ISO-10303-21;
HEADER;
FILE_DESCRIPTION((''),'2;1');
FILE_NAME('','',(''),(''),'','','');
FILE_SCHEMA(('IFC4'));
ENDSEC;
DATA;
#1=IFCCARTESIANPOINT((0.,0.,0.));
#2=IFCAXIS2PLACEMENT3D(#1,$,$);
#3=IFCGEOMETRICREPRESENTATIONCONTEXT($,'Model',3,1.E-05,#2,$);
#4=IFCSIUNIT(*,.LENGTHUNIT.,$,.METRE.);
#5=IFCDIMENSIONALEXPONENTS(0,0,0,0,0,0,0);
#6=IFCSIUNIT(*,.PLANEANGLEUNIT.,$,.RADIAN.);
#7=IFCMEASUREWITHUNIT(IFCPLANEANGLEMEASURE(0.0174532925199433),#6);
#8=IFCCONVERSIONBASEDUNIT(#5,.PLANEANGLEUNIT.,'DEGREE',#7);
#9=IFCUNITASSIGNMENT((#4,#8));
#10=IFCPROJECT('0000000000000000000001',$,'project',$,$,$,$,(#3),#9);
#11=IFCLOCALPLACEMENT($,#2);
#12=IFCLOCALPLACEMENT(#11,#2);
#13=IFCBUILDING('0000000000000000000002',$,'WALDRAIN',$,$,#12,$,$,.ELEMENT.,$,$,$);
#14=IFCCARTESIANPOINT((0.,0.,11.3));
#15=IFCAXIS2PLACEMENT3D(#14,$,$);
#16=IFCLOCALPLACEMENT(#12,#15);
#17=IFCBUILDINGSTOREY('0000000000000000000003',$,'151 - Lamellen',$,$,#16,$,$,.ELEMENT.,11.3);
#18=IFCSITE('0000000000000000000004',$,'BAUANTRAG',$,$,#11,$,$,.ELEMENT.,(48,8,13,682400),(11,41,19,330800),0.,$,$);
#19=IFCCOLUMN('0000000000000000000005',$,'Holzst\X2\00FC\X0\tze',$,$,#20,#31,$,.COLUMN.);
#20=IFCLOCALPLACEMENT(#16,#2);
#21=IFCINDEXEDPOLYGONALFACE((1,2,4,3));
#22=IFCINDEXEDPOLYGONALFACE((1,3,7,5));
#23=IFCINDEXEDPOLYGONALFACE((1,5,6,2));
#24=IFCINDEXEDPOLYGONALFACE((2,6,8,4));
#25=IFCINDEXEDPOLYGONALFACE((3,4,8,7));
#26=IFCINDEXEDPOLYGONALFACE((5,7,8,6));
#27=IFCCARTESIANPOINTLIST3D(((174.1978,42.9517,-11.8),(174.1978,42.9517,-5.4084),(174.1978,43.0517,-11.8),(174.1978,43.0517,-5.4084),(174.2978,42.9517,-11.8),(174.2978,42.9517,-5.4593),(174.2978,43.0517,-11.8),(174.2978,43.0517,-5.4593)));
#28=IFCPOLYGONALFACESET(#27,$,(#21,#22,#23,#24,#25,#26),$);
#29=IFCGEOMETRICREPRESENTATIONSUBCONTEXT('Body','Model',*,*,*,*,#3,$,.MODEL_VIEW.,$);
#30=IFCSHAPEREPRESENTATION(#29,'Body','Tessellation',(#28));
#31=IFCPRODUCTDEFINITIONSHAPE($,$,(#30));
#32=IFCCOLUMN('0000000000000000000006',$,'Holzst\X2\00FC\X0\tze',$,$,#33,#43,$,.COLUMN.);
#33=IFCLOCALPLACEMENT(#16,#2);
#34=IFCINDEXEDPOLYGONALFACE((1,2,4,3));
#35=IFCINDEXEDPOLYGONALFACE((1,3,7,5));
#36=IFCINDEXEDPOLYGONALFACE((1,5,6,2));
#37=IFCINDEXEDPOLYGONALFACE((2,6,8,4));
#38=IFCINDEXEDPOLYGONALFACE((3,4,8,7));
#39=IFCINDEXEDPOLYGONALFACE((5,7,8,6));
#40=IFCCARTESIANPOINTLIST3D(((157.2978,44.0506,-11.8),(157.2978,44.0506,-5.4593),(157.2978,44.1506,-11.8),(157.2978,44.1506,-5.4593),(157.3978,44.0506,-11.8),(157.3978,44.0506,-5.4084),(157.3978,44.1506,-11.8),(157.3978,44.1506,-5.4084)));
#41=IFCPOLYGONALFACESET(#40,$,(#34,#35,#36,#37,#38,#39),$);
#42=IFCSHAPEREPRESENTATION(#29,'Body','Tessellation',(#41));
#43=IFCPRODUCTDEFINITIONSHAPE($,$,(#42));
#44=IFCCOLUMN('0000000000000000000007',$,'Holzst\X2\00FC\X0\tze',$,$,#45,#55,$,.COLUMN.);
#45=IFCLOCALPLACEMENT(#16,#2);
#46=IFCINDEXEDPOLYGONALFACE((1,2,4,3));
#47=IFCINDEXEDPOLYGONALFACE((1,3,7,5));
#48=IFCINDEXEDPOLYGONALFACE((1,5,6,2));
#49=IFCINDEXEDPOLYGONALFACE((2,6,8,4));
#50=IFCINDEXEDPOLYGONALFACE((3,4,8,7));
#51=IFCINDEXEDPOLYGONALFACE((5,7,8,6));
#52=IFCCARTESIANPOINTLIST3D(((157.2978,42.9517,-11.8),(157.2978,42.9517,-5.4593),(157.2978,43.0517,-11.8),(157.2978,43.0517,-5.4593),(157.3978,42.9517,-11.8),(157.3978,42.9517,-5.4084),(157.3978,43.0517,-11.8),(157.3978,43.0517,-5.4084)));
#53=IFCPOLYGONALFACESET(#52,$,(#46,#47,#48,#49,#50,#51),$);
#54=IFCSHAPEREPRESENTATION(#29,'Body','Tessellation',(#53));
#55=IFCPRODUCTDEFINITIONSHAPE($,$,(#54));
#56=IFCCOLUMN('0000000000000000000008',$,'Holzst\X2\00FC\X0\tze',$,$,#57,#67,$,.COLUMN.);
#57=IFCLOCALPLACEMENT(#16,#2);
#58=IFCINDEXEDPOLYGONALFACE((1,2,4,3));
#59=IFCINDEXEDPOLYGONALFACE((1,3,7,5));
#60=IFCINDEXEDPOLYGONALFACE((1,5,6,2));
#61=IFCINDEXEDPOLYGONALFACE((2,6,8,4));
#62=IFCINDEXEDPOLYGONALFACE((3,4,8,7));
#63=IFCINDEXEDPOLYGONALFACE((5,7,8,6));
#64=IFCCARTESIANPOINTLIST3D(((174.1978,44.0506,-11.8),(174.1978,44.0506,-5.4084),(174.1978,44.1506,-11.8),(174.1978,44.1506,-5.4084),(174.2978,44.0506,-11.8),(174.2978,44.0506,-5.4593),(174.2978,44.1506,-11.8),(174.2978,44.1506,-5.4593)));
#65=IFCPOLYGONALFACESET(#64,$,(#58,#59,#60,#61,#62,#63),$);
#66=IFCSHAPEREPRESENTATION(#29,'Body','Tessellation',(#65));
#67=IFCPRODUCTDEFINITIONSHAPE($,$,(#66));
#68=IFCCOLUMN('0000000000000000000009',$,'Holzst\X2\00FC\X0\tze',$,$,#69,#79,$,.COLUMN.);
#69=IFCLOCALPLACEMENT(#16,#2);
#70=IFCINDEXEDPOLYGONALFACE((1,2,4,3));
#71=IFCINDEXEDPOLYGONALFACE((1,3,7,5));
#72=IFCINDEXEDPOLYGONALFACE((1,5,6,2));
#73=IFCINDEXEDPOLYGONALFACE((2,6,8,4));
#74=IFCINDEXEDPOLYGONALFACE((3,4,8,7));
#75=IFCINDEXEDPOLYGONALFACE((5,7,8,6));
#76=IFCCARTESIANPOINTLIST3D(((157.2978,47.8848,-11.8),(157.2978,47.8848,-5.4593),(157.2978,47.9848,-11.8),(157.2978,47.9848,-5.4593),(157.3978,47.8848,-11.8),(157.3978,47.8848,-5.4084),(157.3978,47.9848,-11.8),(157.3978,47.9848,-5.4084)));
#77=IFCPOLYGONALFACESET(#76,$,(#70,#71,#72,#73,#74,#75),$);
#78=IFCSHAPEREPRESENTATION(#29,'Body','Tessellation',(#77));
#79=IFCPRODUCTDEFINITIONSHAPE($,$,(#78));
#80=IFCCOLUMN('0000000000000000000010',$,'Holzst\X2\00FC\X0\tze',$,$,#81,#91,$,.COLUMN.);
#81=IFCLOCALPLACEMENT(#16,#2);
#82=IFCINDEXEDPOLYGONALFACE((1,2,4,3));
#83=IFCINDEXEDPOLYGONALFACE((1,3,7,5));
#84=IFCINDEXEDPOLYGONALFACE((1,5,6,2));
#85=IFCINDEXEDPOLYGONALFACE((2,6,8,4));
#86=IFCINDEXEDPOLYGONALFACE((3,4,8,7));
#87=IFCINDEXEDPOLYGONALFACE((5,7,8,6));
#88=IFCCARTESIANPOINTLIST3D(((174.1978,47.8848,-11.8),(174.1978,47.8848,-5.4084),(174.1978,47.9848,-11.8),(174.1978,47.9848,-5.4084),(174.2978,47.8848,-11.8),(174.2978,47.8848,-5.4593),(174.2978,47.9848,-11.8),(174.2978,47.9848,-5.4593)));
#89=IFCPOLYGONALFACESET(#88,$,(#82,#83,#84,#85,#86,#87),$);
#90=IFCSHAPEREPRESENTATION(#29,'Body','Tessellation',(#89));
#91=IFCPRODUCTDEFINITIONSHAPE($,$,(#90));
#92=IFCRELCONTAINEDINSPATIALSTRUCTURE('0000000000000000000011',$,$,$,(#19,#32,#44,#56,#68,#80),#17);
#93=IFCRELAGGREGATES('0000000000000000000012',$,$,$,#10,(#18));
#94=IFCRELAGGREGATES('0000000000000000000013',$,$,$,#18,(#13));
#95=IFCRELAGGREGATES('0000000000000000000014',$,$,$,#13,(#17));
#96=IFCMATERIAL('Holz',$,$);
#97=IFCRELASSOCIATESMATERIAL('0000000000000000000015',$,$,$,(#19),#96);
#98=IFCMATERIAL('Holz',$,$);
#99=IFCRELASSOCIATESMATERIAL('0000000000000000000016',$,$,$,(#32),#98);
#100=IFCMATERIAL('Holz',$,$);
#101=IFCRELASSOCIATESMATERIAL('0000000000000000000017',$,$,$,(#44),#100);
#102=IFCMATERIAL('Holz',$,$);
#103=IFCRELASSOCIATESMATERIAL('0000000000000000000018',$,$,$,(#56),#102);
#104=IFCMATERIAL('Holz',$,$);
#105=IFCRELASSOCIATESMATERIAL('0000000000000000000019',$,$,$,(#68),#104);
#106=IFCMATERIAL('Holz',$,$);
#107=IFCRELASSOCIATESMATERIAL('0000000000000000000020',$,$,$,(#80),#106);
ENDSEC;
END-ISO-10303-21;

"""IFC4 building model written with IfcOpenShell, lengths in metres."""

from ifc_helpers import new_model, entity, si_unit, converted_unit, frame, frame_2d, origin, origin_with_axes, place, context, subcontext, project, spatial, rectangle, extrude, clip, halfspace, material, element, save


model = new_model("IFC4")

# Units and contexts
model_context = context("Model", 3, precision=1e-05, world=origin())
body_context = subcontext(model_context, "Body", "Model", "MODEL_VIEW")
ifc_project = project(units=[si_unit("LENGTHUNIT", "METRE"), converted_unit("PLANEANGLEUNIT", "DEGREE", entity("IfcPlaneAngleMeasure", 0.0174532925199433), si_unit("PLANEANGLEUNIT", "RADIAN"), dimensions=[0, 0, 0, 0, 0, 0, 0])], contexts=[model_context])

# Site, building, storey
site_placement = place(None, origin())
site = spatial("IfcSite", under=ifc_project, at=site_placement, Name="BAUANTRAG", CompositionType="ELEMENT", RefLatitude=(48, 8, 13, 682400), RefLongitude=(11, 41, 19, 330800), RefElevation=0.0)
building_placement = place(site_placement, origin())
building = spatial("IfcBuilding", under=site, at=building_placement, Name="WALDRAIN", CompositionType="ELEMENT")
storey_placement = place(building_placement, frame((0.0, 0.0, 11.3)))
storey = spatial("IfcBuildingStorey", under=building, at=storey_placement, Name="151 - Lamellen", CompositionType="ELEMENT", Elevation=11.3)

# Columns
ifc_material_1 = material(Name="Holz")
column_1_placement = place(storey_placement, frame((174.2978, 42.9517, -11.8)))
element("IfcColumn", 1, at=column_1_placement, inside=storey, material=ifc_material_1, Name="Holzstütze", PredefinedType="COLUMN", context=body_context, shape_type="Clipping", body=[
    clip(extrude(rectangle(XDim=0.1, YDim=0.1, at=frame_2d((-0.05, 0.05), x_axis=(0.0, 1.0))), origin_with_axes(), (0.0, 0.0, 1.0), 6.3916), halfspace(frame((-0.05, 0.05, 6.3661), z_axis=(-0.45399, 0.0, -0.891007), x_axis=(0.891007, 0.0, -0.45399)), True)),
])
ifc_material_2 = material(Name="Holz")
column_2_placement = place(storey_placement, frame((157.3978, 44.0506, -11.8)))
element("IfcColumn", 2, at=column_2_placement, inside=storey, material=ifc_material_2, Name="Holzstütze", PredefinedType="COLUMN", context=body_context, shape_type="Clipping", body=[
    clip(extrude(rectangle(XDim=0.1, YDim=0.1, at=frame_2d((-0.05, 0.05), x_axis=(0.0, 1.0))), origin_with_axes(), (0.0, 0.0, 1.0), 6.3916), halfspace(frame((-0.05, 0.05, 6.3661), z_axis=(0.45399, 0.0, -0.891007), x_axis=(-0.891007, 0.0, -0.45399)), True)),
])
ifc_material_3 = material(Name="Holz")
column_3_placement = place(storey_placement, frame((157.3978, 42.9517, -11.8)))
element("IfcColumn", 3, at=column_3_placement, inside=storey, material=ifc_material_3, Name="Holzstütze", PredefinedType="COLUMN", context=body_context, shape_type="Clipping", body=[
    clip(extrude(rectangle(XDim=0.1, YDim=0.1, at=frame_2d((-0.05, 0.05), x_axis=(0.0, 1.0))), origin_with_axes(), (0.0, 0.0, 1.0), 6.3916), halfspace(frame((-0.05, 0.05, 6.3661), z_axis=(0.45399, 0.0, -0.891007), x_axis=(-0.891007, 0.0, -0.45399)), True)),
])
ifc_material_4 = material(Name="Holz")
column_4_placement = place(storey_placement, frame((174.2978, 44.0506, -11.8)))
element("IfcColumn", 4, at=column_4_placement, inside=storey, material=ifc_material_4, Name="Holzstütze", PredefinedType="COLUMN", context=body_context, shape_type="Clipping", body=[
    clip(extrude(rectangle(XDim=0.1, YDim=0.1, at=frame_2d((-0.05, 0.05), x_axis=(0.0, 1.0))), origin_with_axes(), (0.0, 0.0, 1.0), 6.3916), halfspace(frame((-0.05, 0.05, 6.3661), z_axis=(-0.45399, 0.0, -0.891007), x_axis=(0.891007, 0.0, -0.45399)), True)),
])
ifc_material_5 = material(Name="Holz")
column_5_placement = place(storey_placement, frame((157.3978, 47.8848, -11.8)))
element("IfcColumn", 5, at=column_5_placement, inside=storey, material=ifc_material_5, Name="Holzstütze", PredefinedType="COLUMN", context=body_context, shape_type="Clipping", body=[
    clip(extrude(rectangle(XDim=0.1, YDim=0.1, at=frame_2d((-0.05, 0.05), x_axis=(0.0, 1.0))), origin_with_axes(), (0.0, 0.0, 1.0), 6.3916), halfspace(frame((-0.05, 0.05, 6.3661), z_axis=(0.45399, 0.0, -0.891007), x_axis=(0.0, 1.0, 0.0)), True)),
])
ifc_material_6 = material(Name="Holz")
column_6_placement = place(storey_placement, frame((174.2978, 47.8848, -11.8)))
element("IfcColumn", 6, at=column_6_placement, inside=storey, material=ifc_material_6, Name="Holzstütze", PredefinedType="COLUMN", context=body_context, shape_type="Clipping", body=[
    clip(extrude(rectangle(XDim=0.1, YDim=0.1, at=frame_2d((-0.05, 0.05), x_axis=(0.0, 1.0))), origin_with_axes(), (0.0, 0.0, 1.0), 6.3916), halfspace(frame((-0.05, 0.05, 6.3661), z_axis=(-0.45399, 0.0, -0.891007), x_axis=(0.891007, 0.0, -0.45399)), True)),
])

save(model, "model.ifc")
